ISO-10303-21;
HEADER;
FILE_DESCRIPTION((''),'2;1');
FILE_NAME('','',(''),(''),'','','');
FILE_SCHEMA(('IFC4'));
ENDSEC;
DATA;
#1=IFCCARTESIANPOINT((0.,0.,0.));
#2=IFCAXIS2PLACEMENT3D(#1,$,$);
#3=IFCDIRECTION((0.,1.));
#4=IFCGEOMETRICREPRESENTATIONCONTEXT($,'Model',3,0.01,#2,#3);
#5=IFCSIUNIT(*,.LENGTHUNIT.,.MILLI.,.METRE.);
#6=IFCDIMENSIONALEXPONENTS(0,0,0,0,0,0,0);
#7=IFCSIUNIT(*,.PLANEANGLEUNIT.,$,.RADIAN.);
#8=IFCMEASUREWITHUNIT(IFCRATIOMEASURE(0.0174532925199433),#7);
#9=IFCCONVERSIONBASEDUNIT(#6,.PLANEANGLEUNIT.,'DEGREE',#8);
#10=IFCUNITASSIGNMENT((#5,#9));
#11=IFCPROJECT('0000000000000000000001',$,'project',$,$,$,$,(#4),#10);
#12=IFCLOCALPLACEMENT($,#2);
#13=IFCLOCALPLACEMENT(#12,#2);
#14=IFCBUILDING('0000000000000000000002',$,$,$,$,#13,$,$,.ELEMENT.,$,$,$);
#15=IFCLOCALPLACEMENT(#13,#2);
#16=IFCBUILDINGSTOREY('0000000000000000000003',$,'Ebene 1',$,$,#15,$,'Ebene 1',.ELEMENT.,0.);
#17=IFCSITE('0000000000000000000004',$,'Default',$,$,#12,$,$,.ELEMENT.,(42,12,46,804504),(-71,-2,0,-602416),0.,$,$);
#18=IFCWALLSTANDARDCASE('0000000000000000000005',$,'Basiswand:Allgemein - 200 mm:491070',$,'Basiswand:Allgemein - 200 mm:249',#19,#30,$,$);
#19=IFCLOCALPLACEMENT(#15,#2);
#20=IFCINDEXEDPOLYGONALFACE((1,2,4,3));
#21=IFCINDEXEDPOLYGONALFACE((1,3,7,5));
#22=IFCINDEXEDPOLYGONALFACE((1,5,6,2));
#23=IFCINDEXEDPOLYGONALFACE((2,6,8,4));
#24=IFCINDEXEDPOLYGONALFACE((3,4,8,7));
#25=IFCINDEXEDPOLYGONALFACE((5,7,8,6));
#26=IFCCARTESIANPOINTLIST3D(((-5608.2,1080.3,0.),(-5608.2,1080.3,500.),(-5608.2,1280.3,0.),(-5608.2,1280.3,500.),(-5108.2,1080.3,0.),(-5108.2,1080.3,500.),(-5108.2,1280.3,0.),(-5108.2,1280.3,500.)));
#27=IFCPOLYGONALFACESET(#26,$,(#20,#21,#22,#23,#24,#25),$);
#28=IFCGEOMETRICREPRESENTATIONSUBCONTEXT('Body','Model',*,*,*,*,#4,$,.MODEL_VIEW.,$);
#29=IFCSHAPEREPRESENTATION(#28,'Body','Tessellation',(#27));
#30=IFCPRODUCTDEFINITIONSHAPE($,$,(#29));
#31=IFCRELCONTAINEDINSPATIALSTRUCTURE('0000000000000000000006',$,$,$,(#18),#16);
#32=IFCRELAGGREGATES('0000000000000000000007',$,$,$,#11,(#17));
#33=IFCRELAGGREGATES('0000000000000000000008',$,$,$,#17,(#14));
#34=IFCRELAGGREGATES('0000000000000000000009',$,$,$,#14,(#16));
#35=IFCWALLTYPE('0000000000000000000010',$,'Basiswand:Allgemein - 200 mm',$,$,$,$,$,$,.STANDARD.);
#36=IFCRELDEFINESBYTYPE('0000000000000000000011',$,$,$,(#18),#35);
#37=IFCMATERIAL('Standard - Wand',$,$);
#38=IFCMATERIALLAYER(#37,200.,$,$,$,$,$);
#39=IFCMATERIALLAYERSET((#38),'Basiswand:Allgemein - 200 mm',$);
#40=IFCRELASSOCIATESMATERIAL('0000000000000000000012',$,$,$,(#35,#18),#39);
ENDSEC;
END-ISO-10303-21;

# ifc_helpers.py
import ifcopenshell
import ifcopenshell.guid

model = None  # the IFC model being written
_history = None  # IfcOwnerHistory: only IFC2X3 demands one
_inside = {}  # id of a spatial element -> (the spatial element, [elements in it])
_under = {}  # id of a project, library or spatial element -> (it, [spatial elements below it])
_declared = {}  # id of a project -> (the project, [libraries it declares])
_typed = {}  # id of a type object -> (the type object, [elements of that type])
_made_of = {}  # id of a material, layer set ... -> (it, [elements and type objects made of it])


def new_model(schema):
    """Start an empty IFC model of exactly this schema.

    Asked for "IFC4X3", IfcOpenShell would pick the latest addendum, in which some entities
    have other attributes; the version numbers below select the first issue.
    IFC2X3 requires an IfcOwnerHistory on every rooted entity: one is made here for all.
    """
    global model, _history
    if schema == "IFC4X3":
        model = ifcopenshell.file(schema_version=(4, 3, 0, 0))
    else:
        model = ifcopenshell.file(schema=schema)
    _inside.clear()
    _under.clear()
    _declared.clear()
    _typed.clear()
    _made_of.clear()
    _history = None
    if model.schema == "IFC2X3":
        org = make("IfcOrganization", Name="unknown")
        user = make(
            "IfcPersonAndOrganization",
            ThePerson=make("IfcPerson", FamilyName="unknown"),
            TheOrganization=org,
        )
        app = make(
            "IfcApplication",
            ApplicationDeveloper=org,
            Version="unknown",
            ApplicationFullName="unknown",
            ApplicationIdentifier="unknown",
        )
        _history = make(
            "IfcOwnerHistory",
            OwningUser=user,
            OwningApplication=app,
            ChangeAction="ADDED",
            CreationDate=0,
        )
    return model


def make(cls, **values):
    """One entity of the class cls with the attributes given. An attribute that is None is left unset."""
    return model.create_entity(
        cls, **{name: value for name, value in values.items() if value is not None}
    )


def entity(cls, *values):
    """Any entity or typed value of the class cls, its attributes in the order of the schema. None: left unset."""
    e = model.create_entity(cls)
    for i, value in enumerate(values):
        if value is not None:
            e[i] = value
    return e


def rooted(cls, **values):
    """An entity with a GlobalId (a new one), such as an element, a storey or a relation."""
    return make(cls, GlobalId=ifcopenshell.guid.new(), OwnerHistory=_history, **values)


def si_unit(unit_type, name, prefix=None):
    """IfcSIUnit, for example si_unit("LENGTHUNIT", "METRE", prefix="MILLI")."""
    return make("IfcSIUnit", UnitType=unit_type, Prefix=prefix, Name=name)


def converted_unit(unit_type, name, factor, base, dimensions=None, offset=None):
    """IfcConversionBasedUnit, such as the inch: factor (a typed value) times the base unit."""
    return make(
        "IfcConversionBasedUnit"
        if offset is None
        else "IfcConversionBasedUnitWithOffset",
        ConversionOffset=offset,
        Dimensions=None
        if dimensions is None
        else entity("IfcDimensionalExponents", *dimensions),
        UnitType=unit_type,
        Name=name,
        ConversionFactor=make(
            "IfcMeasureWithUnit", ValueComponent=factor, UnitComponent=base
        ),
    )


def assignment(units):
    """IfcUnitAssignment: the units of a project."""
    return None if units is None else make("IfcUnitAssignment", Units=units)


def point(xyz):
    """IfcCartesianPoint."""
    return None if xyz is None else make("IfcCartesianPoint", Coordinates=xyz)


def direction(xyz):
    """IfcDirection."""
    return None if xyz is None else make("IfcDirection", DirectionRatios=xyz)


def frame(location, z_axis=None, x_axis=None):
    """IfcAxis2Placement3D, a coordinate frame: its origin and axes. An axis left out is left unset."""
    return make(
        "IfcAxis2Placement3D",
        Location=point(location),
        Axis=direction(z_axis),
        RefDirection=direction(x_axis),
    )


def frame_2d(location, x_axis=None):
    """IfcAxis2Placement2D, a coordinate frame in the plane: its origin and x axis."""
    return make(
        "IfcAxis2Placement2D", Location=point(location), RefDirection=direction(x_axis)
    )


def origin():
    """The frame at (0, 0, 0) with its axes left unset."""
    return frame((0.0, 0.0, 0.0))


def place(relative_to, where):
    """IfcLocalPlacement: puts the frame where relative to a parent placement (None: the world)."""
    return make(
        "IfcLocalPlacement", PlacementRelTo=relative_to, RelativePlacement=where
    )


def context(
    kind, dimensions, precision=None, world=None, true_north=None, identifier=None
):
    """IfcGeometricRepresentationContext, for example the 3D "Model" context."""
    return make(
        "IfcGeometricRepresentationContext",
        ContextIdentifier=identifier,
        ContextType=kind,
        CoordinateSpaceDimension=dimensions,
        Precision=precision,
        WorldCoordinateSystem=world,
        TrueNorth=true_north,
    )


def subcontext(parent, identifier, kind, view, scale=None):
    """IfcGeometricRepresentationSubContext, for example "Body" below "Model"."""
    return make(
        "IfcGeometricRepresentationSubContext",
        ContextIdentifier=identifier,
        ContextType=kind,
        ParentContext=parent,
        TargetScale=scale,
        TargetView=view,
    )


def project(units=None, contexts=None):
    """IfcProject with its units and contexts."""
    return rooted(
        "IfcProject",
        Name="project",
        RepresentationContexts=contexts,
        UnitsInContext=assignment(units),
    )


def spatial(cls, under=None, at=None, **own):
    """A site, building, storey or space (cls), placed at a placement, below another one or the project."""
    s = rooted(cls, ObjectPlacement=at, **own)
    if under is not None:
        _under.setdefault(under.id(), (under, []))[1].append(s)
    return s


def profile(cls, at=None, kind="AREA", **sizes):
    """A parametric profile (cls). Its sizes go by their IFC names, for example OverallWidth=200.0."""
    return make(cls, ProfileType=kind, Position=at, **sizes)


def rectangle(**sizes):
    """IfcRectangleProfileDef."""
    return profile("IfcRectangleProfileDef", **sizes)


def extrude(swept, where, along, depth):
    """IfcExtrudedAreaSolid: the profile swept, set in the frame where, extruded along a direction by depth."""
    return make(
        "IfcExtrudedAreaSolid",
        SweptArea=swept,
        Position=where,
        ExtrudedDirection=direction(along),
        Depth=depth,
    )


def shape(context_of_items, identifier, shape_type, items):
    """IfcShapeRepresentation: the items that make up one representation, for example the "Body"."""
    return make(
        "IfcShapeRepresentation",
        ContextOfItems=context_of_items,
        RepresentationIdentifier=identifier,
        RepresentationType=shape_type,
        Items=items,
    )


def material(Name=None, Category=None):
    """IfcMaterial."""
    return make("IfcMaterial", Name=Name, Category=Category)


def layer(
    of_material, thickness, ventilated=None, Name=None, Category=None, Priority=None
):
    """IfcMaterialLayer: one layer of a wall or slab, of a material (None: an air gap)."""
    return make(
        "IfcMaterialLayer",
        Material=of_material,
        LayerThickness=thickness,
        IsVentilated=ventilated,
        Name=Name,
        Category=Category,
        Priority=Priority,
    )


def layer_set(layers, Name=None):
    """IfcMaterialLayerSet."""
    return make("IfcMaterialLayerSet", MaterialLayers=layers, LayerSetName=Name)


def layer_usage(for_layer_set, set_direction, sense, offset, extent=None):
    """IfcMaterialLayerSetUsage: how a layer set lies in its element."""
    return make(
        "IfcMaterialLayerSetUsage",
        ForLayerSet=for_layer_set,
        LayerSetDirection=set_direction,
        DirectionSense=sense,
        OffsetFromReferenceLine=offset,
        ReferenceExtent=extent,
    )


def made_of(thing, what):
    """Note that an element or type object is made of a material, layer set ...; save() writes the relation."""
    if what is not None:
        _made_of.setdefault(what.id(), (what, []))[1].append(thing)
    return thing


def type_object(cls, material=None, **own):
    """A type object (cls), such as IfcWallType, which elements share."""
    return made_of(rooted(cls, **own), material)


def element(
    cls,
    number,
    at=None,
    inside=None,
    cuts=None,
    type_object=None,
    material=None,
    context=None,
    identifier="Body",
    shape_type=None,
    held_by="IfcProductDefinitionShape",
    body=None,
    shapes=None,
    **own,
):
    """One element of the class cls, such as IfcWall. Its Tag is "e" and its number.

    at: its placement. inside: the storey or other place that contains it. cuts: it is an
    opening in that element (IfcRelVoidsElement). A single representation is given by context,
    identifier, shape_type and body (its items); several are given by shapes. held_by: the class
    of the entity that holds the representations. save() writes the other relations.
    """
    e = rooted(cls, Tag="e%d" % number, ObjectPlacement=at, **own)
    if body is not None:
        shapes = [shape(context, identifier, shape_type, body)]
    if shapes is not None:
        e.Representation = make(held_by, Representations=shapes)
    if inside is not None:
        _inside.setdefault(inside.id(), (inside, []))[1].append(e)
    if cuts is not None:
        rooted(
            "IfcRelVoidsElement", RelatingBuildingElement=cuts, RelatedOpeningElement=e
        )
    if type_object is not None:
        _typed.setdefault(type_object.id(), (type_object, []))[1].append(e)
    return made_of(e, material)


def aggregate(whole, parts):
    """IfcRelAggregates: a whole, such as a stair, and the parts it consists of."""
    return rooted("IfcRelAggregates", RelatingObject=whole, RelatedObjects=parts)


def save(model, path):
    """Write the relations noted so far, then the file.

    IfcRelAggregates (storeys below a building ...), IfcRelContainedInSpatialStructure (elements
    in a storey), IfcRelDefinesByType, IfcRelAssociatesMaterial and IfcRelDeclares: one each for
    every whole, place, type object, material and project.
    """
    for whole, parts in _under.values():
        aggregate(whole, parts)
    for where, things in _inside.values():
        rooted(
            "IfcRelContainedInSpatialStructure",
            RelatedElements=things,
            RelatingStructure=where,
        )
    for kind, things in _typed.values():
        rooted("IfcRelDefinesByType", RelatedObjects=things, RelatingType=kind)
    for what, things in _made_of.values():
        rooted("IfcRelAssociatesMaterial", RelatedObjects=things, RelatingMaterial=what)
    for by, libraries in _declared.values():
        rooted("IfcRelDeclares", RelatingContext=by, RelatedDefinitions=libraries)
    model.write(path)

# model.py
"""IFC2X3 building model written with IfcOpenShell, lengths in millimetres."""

from ifc_helpers import new_model, entity, si_unit, converted_unit, direction, frame, frame_2d, origin, place, context, subcontext, project, spatial, rectangle, extrude, material, layer, layer_set, layer_usage, type_object, element, save


model = new_model("IFC2X3")

# Units and contexts
model_context = context("Model", 3, precision=0.01, world=origin(), true_north=direction((0.0, 1.0)))
body_context = subcontext(model_context, "Body", "Model", "MODEL_VIEW")
ifc_project = project(units=[si_unit("LENGTHUNIT", "METRE", prefix="MILLI"), converted_unit("PLANEANGLEUNIT", "DEGREE", entity("IfcRatioMeasure", 0.0174532925199433), si_unit("PLANEANGLEUNIT", "RADIAN"), dimensions=[0, 0, 0, 0, 0, 0, 0])], contexts=[model_context])

# Site, building, storey
site_placement = place(None, origin())
site = spatial("IfcSite", under=ifc_project, at=site_placement, Name="Default", CompositionType="ELEMENT", RefLatitude=(42, 12, 46, 804504), RefLongitude=(-71, -2, 0, -602416), RefElevation=0.0)
building_placement = place(site_placement, origin())
building = spatial("IfcBuilding", under=site, at=building_placement, CompositionType="ELEMENT")
storey_placement = place(building_placement, origin())
storey = spatial("IfcBuildingStorey", under=building, at=storey_placement, Name="Ebene 1", LongName="Ebene 1", CompositionType="ELEMENT", Elevation=0.0)

# Wall
ifc_material = material(Name="Standard - Wand")
ifc_layer = layer(ifc_material, 200.0)
ifc_layer_set = layer_set([ifc_layer], Name="Basiswand:Allgemein - 200 mm")
ifc_layer_usage = layer_usage(ifc_layer_set, "AXIS2", "NEGATIVE", 100.0)
wall_type = type_object("IfcWallType", Name="Basiswand:Allgemein - 200 mm", PredefinedType="STANDARD", material=ifc_layer_set)
wall_placement = place(storey_placement, frame((-5608.2, 1180.3, 0.0)))
element("IfcWallStandardCase", 1, at=wall_placement, inside=storey, type_object=wall_type, material=ifc_layer_usage, Name="Basiswand:Allgemein - 200 mm:491070", ObjectType="Basiswand:Allgemein - 200 mm:249", context=body_context, shape_type="SweptSolid", body=[
    extrude(rectangle(XDim=500.0, YDim=200.0, at=frame_2d((250.0, 0.0), x_axis=(-1.0, 0.0))), origin(), (0.0, 0.0, 1.0), 500.0),
])

save(model, "model.ifc")
